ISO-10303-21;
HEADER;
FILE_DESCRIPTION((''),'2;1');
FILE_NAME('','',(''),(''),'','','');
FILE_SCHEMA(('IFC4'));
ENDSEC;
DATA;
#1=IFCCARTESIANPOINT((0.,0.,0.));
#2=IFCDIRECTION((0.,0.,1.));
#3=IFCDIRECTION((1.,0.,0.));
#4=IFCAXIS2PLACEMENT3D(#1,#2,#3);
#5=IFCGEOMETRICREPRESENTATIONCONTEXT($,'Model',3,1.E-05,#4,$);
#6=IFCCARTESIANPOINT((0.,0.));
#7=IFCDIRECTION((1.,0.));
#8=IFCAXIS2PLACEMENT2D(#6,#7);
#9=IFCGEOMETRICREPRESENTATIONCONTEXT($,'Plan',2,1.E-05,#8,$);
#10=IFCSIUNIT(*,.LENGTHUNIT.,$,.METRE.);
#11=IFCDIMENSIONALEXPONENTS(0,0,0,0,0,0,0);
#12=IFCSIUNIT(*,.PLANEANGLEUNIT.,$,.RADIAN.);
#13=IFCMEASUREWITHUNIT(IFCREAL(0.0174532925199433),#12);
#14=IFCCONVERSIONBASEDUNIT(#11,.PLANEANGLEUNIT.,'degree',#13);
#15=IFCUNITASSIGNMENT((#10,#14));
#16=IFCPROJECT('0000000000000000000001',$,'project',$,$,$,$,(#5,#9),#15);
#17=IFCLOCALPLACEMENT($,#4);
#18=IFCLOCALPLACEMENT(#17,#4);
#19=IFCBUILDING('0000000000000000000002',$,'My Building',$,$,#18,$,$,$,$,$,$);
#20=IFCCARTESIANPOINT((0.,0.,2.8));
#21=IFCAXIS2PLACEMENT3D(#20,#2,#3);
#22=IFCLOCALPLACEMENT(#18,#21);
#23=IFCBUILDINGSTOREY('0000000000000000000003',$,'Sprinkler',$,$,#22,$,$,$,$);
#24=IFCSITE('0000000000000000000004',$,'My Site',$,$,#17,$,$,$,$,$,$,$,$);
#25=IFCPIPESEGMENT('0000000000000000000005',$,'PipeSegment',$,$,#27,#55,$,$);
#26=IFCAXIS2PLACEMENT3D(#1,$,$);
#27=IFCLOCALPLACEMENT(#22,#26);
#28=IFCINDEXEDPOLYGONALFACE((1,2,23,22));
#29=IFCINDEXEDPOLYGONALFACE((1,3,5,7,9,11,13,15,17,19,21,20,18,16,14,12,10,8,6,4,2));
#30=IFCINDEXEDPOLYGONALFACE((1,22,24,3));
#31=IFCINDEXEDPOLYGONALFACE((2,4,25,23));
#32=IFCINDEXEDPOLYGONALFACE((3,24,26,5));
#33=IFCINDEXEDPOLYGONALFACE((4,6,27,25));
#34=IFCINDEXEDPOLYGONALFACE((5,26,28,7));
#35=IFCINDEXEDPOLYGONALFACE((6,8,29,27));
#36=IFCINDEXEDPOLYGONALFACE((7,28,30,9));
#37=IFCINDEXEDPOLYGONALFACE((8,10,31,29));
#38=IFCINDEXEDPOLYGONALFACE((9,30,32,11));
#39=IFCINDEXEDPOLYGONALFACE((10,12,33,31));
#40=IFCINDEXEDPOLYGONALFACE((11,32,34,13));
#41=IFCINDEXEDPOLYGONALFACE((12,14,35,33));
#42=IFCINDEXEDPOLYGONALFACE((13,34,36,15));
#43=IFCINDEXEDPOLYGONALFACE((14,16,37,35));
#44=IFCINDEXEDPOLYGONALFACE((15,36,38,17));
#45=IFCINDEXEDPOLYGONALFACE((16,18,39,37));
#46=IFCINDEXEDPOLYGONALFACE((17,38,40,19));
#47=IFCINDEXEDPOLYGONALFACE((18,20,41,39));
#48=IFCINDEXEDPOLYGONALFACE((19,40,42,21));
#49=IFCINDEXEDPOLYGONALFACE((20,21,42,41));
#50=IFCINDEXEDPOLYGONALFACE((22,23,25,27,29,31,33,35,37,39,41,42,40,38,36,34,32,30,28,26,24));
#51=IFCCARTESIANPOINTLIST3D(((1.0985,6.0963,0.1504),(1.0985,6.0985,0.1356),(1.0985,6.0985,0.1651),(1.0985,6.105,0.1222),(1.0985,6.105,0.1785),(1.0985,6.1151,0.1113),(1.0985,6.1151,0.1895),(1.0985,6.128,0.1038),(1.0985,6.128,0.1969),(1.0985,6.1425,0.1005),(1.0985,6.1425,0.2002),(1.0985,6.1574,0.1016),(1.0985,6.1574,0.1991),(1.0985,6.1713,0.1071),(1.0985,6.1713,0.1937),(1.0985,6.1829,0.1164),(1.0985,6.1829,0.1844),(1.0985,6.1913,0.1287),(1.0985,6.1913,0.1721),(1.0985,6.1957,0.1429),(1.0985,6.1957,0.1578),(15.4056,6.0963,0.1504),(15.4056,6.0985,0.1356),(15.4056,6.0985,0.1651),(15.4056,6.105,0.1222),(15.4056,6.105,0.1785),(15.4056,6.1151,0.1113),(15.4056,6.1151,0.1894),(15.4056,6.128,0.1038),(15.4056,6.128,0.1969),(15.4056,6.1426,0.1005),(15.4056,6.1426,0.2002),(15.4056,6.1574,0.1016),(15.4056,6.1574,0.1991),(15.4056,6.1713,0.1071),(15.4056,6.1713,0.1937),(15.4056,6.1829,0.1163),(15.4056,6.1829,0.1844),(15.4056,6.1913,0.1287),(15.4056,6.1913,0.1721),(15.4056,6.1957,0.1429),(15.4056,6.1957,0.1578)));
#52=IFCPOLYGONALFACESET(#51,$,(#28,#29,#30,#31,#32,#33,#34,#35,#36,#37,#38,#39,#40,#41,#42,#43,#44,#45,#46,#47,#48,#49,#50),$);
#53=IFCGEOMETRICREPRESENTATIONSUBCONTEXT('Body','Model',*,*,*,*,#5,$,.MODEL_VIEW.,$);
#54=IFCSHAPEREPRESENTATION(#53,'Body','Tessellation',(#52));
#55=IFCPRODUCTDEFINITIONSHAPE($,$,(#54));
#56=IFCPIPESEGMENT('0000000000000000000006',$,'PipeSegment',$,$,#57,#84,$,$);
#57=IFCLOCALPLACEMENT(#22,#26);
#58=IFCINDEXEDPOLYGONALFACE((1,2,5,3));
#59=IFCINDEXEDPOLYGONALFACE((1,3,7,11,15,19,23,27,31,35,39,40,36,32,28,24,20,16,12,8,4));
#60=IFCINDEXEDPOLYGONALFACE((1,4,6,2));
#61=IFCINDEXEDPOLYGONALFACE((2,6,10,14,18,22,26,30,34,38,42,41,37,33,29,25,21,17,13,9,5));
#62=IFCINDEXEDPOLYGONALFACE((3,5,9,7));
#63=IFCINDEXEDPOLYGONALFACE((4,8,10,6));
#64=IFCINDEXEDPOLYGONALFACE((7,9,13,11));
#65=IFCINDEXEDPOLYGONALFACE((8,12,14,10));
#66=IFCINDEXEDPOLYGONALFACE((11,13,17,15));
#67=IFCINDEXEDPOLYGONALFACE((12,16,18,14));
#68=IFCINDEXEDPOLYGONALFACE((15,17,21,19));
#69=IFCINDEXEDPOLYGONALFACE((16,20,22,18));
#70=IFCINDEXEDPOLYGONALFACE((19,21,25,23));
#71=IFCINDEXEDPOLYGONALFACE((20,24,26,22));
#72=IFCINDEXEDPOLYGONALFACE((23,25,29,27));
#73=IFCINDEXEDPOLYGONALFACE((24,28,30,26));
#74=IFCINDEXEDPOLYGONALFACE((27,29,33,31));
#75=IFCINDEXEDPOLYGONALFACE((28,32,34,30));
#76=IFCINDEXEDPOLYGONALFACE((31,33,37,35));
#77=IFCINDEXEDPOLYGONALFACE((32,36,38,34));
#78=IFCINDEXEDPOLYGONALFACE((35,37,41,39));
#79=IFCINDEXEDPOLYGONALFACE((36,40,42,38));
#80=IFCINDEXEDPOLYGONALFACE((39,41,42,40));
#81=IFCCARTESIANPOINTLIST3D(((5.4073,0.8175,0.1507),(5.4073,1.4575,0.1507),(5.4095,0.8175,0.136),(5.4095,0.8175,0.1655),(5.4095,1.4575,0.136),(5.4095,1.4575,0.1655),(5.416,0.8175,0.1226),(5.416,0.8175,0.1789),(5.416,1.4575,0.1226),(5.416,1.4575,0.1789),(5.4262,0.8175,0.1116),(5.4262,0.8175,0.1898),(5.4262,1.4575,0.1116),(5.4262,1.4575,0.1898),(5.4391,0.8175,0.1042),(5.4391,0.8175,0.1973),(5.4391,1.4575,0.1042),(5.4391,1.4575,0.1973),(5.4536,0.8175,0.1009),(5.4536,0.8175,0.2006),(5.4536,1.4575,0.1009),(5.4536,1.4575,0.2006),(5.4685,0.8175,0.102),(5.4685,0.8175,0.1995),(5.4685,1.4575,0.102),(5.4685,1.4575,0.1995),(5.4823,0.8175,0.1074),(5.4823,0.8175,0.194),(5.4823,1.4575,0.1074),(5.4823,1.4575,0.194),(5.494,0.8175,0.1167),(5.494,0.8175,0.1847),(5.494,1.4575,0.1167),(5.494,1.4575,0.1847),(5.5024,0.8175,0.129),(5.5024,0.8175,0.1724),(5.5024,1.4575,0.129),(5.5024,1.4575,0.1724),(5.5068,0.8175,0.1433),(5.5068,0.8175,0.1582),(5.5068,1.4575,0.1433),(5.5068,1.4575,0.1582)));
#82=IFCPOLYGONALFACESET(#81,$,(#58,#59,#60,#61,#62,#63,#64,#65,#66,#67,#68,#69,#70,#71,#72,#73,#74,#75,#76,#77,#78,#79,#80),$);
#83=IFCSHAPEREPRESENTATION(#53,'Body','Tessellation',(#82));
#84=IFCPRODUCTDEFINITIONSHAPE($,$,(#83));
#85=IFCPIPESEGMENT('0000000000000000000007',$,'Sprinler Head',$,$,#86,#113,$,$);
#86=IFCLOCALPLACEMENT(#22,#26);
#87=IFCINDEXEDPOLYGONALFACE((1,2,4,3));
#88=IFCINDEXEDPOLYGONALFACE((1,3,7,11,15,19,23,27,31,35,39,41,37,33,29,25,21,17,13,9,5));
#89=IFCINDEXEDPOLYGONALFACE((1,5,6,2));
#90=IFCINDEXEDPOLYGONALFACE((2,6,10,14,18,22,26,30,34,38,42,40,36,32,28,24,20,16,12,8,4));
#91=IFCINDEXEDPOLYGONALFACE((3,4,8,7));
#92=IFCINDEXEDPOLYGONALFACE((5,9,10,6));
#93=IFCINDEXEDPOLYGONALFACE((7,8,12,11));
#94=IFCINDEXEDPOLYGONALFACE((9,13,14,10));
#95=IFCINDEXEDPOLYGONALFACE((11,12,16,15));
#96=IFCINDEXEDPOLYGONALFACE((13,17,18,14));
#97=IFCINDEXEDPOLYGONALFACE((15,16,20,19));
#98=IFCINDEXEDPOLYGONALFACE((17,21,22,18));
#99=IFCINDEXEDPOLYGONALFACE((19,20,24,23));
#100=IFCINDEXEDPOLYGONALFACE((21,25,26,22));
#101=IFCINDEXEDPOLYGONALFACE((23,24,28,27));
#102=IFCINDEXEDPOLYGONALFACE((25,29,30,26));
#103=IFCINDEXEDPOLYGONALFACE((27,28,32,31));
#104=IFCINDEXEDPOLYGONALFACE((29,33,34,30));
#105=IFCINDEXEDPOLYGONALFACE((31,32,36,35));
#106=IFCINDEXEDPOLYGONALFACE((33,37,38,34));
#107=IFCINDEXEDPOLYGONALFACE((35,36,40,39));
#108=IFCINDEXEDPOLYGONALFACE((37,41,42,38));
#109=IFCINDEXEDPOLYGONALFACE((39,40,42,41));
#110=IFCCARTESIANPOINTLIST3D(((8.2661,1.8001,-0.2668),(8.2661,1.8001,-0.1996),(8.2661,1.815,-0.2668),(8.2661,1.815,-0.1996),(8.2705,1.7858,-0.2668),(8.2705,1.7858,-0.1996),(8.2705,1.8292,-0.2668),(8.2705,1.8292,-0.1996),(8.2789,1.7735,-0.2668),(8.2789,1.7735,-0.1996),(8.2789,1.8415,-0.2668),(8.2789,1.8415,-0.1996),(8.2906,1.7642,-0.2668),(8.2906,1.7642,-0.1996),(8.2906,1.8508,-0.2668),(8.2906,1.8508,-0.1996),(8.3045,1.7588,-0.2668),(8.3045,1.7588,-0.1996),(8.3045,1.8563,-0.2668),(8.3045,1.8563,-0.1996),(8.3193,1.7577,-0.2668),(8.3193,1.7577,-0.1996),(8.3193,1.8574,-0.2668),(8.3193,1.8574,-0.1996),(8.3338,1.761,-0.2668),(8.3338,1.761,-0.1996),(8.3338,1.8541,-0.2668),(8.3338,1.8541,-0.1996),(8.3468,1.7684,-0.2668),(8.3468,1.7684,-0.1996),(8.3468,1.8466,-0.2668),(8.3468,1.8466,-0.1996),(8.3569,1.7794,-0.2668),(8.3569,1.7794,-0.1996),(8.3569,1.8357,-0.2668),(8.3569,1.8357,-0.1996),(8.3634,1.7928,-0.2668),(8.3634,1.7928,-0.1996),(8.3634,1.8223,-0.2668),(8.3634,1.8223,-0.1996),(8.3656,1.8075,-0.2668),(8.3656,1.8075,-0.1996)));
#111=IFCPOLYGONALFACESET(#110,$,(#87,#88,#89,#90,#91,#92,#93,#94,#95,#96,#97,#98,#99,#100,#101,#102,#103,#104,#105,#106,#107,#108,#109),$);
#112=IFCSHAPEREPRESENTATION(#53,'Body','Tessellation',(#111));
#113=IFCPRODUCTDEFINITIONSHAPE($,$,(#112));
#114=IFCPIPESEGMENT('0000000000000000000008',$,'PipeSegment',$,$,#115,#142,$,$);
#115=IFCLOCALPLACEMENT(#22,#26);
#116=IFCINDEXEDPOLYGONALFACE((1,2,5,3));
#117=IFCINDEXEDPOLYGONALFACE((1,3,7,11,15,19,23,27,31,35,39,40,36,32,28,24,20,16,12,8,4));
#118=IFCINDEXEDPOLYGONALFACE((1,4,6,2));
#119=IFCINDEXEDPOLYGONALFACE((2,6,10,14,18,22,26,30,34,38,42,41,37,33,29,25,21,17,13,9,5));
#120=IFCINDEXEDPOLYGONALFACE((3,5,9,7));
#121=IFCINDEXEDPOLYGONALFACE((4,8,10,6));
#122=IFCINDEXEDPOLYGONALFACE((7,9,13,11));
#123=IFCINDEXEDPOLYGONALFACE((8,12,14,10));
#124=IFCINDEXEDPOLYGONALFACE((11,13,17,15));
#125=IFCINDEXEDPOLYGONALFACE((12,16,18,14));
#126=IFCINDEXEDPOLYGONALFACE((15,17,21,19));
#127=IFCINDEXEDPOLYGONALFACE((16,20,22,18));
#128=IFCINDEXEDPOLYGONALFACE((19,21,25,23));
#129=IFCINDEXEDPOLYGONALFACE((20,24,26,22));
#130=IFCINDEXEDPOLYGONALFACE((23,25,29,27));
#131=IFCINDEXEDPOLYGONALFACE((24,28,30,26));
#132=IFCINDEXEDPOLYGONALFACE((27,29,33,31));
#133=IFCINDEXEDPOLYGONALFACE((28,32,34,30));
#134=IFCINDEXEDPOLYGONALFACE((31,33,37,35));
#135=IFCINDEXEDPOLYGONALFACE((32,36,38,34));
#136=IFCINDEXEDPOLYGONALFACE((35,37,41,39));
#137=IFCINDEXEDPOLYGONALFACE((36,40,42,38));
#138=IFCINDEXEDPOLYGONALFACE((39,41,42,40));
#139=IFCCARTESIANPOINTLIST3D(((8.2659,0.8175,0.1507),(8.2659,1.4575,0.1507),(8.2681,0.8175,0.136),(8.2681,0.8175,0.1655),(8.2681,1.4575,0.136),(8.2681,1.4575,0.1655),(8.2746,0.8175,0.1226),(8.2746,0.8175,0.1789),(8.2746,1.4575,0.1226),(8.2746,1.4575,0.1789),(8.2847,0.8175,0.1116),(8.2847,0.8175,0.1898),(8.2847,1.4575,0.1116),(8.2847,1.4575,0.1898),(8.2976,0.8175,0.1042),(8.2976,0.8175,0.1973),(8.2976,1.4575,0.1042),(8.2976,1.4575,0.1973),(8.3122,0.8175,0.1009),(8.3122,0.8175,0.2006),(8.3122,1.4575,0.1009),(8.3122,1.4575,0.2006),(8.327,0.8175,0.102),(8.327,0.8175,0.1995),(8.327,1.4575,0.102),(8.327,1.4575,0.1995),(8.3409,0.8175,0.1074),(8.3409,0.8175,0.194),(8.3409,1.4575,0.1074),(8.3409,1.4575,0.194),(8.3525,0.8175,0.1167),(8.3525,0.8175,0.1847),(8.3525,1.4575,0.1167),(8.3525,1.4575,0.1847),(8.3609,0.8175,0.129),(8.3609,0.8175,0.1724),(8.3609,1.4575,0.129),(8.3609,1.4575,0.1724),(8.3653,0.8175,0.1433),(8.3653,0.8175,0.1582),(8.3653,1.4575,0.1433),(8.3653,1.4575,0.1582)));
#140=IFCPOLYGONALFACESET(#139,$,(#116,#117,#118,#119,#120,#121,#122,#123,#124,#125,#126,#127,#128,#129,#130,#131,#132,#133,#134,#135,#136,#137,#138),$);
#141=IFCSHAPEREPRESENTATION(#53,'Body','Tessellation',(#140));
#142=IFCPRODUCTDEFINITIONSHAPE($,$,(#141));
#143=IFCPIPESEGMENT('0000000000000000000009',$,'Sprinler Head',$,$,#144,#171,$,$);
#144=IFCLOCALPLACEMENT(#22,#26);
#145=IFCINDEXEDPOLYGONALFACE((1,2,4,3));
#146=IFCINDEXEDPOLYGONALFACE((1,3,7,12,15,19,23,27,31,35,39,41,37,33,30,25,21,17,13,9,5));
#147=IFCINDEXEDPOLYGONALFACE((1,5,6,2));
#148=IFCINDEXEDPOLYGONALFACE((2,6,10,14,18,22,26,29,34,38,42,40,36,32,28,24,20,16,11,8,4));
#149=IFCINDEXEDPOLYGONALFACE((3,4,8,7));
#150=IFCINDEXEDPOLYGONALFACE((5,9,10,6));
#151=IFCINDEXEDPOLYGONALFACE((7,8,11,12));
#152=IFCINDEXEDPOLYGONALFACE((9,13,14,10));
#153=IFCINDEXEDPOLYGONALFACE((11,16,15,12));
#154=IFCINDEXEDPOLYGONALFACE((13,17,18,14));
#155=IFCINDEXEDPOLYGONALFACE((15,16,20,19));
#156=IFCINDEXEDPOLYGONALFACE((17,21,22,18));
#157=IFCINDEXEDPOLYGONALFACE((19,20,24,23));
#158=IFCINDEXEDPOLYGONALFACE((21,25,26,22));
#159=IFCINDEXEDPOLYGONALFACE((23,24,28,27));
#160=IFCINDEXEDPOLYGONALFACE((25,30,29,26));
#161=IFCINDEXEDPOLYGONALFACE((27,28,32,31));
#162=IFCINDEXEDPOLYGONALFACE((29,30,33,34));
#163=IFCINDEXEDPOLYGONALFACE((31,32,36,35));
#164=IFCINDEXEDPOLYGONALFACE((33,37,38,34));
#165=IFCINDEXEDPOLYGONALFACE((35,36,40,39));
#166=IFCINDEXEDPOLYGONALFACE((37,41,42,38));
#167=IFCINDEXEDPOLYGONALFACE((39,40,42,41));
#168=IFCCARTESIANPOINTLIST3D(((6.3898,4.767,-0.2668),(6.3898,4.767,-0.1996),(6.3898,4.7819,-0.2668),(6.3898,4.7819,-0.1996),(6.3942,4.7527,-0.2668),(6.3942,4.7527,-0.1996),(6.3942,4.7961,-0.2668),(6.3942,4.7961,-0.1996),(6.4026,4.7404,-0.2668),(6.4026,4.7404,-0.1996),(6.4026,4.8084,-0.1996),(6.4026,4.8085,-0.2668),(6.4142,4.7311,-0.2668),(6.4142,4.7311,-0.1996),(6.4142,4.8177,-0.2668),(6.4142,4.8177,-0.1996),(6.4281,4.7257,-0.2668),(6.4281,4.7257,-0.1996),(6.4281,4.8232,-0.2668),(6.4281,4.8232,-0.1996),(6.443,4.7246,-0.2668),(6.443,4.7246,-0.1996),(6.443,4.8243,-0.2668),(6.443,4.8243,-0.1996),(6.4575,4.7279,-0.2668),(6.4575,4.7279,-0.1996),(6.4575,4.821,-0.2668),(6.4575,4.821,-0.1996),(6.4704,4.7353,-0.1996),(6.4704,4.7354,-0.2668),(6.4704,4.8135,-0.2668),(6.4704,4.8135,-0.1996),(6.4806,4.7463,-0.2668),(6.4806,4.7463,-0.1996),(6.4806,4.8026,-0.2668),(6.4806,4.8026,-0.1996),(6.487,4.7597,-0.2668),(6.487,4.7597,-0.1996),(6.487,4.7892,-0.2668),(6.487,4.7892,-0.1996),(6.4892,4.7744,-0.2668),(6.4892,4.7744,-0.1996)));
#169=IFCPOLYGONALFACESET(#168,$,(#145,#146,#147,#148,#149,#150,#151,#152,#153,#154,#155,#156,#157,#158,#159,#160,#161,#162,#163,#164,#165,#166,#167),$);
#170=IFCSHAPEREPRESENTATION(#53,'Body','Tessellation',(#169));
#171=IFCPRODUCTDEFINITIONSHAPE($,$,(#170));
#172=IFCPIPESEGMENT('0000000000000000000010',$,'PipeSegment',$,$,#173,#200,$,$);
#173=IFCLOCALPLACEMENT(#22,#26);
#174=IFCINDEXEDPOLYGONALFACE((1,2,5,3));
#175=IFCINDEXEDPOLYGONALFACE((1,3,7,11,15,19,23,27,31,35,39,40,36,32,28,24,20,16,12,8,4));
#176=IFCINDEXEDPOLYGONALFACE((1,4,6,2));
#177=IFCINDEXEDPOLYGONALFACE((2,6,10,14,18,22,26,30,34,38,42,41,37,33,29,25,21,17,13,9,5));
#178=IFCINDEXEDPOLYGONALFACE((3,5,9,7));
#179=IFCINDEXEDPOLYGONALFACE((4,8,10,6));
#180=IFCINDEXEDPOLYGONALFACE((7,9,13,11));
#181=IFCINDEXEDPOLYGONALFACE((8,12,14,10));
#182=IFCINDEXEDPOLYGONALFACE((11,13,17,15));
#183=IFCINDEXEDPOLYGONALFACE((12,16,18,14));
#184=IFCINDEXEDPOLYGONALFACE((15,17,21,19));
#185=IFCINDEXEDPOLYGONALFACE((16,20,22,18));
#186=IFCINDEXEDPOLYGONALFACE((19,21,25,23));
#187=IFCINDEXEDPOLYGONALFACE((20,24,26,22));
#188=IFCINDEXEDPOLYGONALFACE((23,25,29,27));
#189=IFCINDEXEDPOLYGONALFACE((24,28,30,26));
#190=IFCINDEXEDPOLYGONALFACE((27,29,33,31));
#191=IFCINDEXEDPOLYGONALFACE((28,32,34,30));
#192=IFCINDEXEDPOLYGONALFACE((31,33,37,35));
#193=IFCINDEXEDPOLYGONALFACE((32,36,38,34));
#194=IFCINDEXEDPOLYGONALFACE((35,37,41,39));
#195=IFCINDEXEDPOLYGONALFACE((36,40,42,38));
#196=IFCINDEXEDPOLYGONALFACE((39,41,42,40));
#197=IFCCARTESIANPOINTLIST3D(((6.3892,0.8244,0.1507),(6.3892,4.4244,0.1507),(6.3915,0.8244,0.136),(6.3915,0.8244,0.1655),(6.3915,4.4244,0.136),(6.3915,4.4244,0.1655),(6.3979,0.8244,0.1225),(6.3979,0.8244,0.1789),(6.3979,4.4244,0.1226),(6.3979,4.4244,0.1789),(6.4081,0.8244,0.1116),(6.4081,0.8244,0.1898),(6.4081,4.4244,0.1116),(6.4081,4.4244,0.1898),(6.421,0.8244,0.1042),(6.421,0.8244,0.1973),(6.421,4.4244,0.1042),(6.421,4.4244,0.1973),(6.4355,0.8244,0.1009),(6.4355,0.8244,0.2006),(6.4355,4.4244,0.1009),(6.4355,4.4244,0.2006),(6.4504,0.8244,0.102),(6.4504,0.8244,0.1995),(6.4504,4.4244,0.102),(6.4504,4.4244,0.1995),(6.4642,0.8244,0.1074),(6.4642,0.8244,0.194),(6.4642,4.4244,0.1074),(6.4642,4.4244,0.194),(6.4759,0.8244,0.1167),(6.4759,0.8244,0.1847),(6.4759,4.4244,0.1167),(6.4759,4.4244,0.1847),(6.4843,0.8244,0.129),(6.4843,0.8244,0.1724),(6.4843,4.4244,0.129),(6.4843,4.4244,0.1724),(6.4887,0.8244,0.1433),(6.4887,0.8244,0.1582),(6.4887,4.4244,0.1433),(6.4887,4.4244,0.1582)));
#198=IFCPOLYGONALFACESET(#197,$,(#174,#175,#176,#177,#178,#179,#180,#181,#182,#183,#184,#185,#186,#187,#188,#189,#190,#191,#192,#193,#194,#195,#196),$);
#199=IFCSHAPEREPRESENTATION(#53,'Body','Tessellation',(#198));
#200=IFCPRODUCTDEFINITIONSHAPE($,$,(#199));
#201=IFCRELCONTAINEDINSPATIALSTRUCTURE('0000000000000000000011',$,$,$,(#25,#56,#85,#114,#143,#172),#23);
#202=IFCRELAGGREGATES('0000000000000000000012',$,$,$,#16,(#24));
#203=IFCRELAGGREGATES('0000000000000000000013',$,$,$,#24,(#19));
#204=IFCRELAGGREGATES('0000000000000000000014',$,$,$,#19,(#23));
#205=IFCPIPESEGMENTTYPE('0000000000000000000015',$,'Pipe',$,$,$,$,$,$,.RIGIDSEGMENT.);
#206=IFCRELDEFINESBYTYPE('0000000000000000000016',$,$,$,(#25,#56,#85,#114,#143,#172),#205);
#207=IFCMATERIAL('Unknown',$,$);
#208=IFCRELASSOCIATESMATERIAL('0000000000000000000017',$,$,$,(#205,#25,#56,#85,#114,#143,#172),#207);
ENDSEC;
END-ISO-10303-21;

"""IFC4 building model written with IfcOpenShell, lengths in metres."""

from ifc_helpers import new_model, entity, si_unit, converted_unit, frame, origin_with_axes, origin_2d_with_axis, place, context, subcontext, project, spatial, circle, extrude, material, material_profile, profile_set, profile_usage, type_object, element, save


model = new_model("IFC4")

# Units and contexts
model_context = context("Model", 3, precision=1e-05, world=origin_with_axes())
plan_context = context("Plan", 2, precision=1e-05, world=origin_2d_with_axis())
body_context = subcontext(model_context, "Body", "Model", "MODEL_VIEW")
ifc_project = project(units=[si_unit("LENGTHUNIT", "METRE"), converted_unit("PLANEANGLEUNIT", "degree", entity("IfcReal", 0.0174532925199433), si_unit("PLANEANGLEUNIT", "RADIAN"), dimensions=[0, 0, 0, 0, 0, 0, 0])], contexts=[model_context, plan_context])

# Site, building, storey
site_placement = place(None, origin_with_axes())
site = spatial("IfcSite", under=ifc_project, at=site_placement, Name="My Site")
building_placement = place(site_placement, origin_with_axes())
building = spatial("IfcBuilding", under=site, at=building_placement, Name="My Building")
storey_placement = place(building_placement, frame((0.0, 0.0, 2.8), z_axis=(0.0, 0.0, 1.0), x_axis=(1.0, 0.0, 0.0)))
storey = spatial("IfcBuildingStorey", under=building, at=storey_placement, Name="Sprinkler")

# Pipe segments
ifc_material = material(Name="Unknown")
ifc_material_profile_1 = material_profile(ifc_material, circle(Radius=0.05))
ifc_profile_set_1 = profile_set([ifc_material_profile_1])
ifc_profile_usage_1 = profile_usage(ifc_profile_set_1, cardinal=5)
pipe_segment_type = type_object("IfcPipeSegmentType", Name="Pipe", PredefinedType="RIGIDSEGMENT", material=ifc_profile_set_1)
pipe_segment_1_placement = place(storey_placement, frame((15.4056, 6.1463, 0.1504), z_axis=(-1.0, -0.000001, 0.0), x_axis=(0.000001, -1.0, 0.0)))
element("IfcPipeSegment", 1, at=pipe_segment_1_placement, inside=storey, type_object=pipe_segment_type, material=ifc_profile_usage_1, Name="PipeSegment", context=body_context, shape_type="SweptSolid", body=[
    extrude(circle(Radius=0.05), origin_with_axes(), (0.0, 0.0, 1.0), 14.3071),
])
ifc_profile_usage_2 = profile_usage(ifc_profile_set_1, cardinal=5)
pipe_segment_2_placement = place(storey_placement, frame((5.4573, 0.8175, 0.1507), z_axis=(0.0, 1.0, 0.0), x_axis=(-1.0, 0.0, 0.0)))
element("IfcPipeSegment", 2, at=pipe_segment_2_placement, inside=storey, type_object=pipe_segment_type, material=ifc_profile_usage_2, Name="PipeSegment", context=body_context, shape_type="SweptSolid", body=[
    extrude(circle(Radius=0.05), origin_with_axes(), (0.0, 0.0, 1.0), 0.64),
])
ifc_profile_usage_3 = profile_usage(ifc_profile_set_1, cardinal=5)
pipe_segment_3_placement = place(storey_placement, frame((8.3156, 1.8075, -0.2668), z_axis=(0.0, -0.000008, 1.0), x_axis=(1.0, 0.0, 0.0)))
element("IfcPipeSegment", 3, at=pipe_segment_3_placement, inside=storey, type_object=pipe_segment_type, material=ifc_profile_usage_3, Name="Sprinler Head", context=body_context, shape_type="SweptSolid", body=[
    extrude(circle(Radius=0.05), origin_with_axes(), (0.0, 0.0, 1.0), 0.0672),
])
ifc_profile_usage_4 = profile_usage(ifc_profile_set_1, cardinal=5)
pipe_segment_4_placement = place(storey_placement, frame((8.3159, 0.8175, 0.1507), z_axis=(0.0, 1.0, 0.0), x_axis=(-1.0, 0.0, 0.0)))
element("IfcPipeSegment", 4, at=pipe_segment_4_placement, inside=storey, type_object=pipe_segment_type, material=ifc_profile_usage_4, Name="PipeSegment", context=body_context, shape_type="SweptSolid", body=[
    extrude(circle(Radius=0.05), origin_with_axes(), (0.0, 0.0, 1.0), 0.64),
])
ifc_profile_usage_5 = profile_usage(ifc_profile_set_1, cardinal=5)
pipe_segment_5_placement = place(storey_placement, frame((6.4392, 4.7744, -0.2668), z_axis=(0.0, -0.000008, 1.0), x_axis=(1.0, 0.0, 0.0)))
element("IfcPipeSegment", 5, at=pipe_segment_5_placement, inside=storey, type_object=pipe_segment_type, material=ifc_profile_usage_5, Name="Sprinler Head", context=body_context, shape_type="SweptSolid", body=[
    extrude(circle(Radius=0.05), origin_with_axes(), (0.0, 0.0, 1.0), 0.0672),
])
ifc_profile_usage_6 = profile_usage(ifc_profile_set_1, cardinal=5)
pipe_segment_6_placement = place(storey_placement, frame((6.4392, 0.8244, 0.1507), z_axis=(0.0, 1.0, 0.000004), x_axis=(-1.0, 0.0, 0.0)))
element("IfcPipeSegment", 6, at=pipe_segment_6_placement, inside=storey, type_object=pipe_segment_type, material=ifc_profile_usage_6, Name="PipeSegment", context=body_context, shape_type="SweptSolid", body=[
    extrude(circle(Radius=0.05), origin_with_axes(), (0.0, 0.0, 1.0), 3.6),
])

save(model, "model.ifc")
